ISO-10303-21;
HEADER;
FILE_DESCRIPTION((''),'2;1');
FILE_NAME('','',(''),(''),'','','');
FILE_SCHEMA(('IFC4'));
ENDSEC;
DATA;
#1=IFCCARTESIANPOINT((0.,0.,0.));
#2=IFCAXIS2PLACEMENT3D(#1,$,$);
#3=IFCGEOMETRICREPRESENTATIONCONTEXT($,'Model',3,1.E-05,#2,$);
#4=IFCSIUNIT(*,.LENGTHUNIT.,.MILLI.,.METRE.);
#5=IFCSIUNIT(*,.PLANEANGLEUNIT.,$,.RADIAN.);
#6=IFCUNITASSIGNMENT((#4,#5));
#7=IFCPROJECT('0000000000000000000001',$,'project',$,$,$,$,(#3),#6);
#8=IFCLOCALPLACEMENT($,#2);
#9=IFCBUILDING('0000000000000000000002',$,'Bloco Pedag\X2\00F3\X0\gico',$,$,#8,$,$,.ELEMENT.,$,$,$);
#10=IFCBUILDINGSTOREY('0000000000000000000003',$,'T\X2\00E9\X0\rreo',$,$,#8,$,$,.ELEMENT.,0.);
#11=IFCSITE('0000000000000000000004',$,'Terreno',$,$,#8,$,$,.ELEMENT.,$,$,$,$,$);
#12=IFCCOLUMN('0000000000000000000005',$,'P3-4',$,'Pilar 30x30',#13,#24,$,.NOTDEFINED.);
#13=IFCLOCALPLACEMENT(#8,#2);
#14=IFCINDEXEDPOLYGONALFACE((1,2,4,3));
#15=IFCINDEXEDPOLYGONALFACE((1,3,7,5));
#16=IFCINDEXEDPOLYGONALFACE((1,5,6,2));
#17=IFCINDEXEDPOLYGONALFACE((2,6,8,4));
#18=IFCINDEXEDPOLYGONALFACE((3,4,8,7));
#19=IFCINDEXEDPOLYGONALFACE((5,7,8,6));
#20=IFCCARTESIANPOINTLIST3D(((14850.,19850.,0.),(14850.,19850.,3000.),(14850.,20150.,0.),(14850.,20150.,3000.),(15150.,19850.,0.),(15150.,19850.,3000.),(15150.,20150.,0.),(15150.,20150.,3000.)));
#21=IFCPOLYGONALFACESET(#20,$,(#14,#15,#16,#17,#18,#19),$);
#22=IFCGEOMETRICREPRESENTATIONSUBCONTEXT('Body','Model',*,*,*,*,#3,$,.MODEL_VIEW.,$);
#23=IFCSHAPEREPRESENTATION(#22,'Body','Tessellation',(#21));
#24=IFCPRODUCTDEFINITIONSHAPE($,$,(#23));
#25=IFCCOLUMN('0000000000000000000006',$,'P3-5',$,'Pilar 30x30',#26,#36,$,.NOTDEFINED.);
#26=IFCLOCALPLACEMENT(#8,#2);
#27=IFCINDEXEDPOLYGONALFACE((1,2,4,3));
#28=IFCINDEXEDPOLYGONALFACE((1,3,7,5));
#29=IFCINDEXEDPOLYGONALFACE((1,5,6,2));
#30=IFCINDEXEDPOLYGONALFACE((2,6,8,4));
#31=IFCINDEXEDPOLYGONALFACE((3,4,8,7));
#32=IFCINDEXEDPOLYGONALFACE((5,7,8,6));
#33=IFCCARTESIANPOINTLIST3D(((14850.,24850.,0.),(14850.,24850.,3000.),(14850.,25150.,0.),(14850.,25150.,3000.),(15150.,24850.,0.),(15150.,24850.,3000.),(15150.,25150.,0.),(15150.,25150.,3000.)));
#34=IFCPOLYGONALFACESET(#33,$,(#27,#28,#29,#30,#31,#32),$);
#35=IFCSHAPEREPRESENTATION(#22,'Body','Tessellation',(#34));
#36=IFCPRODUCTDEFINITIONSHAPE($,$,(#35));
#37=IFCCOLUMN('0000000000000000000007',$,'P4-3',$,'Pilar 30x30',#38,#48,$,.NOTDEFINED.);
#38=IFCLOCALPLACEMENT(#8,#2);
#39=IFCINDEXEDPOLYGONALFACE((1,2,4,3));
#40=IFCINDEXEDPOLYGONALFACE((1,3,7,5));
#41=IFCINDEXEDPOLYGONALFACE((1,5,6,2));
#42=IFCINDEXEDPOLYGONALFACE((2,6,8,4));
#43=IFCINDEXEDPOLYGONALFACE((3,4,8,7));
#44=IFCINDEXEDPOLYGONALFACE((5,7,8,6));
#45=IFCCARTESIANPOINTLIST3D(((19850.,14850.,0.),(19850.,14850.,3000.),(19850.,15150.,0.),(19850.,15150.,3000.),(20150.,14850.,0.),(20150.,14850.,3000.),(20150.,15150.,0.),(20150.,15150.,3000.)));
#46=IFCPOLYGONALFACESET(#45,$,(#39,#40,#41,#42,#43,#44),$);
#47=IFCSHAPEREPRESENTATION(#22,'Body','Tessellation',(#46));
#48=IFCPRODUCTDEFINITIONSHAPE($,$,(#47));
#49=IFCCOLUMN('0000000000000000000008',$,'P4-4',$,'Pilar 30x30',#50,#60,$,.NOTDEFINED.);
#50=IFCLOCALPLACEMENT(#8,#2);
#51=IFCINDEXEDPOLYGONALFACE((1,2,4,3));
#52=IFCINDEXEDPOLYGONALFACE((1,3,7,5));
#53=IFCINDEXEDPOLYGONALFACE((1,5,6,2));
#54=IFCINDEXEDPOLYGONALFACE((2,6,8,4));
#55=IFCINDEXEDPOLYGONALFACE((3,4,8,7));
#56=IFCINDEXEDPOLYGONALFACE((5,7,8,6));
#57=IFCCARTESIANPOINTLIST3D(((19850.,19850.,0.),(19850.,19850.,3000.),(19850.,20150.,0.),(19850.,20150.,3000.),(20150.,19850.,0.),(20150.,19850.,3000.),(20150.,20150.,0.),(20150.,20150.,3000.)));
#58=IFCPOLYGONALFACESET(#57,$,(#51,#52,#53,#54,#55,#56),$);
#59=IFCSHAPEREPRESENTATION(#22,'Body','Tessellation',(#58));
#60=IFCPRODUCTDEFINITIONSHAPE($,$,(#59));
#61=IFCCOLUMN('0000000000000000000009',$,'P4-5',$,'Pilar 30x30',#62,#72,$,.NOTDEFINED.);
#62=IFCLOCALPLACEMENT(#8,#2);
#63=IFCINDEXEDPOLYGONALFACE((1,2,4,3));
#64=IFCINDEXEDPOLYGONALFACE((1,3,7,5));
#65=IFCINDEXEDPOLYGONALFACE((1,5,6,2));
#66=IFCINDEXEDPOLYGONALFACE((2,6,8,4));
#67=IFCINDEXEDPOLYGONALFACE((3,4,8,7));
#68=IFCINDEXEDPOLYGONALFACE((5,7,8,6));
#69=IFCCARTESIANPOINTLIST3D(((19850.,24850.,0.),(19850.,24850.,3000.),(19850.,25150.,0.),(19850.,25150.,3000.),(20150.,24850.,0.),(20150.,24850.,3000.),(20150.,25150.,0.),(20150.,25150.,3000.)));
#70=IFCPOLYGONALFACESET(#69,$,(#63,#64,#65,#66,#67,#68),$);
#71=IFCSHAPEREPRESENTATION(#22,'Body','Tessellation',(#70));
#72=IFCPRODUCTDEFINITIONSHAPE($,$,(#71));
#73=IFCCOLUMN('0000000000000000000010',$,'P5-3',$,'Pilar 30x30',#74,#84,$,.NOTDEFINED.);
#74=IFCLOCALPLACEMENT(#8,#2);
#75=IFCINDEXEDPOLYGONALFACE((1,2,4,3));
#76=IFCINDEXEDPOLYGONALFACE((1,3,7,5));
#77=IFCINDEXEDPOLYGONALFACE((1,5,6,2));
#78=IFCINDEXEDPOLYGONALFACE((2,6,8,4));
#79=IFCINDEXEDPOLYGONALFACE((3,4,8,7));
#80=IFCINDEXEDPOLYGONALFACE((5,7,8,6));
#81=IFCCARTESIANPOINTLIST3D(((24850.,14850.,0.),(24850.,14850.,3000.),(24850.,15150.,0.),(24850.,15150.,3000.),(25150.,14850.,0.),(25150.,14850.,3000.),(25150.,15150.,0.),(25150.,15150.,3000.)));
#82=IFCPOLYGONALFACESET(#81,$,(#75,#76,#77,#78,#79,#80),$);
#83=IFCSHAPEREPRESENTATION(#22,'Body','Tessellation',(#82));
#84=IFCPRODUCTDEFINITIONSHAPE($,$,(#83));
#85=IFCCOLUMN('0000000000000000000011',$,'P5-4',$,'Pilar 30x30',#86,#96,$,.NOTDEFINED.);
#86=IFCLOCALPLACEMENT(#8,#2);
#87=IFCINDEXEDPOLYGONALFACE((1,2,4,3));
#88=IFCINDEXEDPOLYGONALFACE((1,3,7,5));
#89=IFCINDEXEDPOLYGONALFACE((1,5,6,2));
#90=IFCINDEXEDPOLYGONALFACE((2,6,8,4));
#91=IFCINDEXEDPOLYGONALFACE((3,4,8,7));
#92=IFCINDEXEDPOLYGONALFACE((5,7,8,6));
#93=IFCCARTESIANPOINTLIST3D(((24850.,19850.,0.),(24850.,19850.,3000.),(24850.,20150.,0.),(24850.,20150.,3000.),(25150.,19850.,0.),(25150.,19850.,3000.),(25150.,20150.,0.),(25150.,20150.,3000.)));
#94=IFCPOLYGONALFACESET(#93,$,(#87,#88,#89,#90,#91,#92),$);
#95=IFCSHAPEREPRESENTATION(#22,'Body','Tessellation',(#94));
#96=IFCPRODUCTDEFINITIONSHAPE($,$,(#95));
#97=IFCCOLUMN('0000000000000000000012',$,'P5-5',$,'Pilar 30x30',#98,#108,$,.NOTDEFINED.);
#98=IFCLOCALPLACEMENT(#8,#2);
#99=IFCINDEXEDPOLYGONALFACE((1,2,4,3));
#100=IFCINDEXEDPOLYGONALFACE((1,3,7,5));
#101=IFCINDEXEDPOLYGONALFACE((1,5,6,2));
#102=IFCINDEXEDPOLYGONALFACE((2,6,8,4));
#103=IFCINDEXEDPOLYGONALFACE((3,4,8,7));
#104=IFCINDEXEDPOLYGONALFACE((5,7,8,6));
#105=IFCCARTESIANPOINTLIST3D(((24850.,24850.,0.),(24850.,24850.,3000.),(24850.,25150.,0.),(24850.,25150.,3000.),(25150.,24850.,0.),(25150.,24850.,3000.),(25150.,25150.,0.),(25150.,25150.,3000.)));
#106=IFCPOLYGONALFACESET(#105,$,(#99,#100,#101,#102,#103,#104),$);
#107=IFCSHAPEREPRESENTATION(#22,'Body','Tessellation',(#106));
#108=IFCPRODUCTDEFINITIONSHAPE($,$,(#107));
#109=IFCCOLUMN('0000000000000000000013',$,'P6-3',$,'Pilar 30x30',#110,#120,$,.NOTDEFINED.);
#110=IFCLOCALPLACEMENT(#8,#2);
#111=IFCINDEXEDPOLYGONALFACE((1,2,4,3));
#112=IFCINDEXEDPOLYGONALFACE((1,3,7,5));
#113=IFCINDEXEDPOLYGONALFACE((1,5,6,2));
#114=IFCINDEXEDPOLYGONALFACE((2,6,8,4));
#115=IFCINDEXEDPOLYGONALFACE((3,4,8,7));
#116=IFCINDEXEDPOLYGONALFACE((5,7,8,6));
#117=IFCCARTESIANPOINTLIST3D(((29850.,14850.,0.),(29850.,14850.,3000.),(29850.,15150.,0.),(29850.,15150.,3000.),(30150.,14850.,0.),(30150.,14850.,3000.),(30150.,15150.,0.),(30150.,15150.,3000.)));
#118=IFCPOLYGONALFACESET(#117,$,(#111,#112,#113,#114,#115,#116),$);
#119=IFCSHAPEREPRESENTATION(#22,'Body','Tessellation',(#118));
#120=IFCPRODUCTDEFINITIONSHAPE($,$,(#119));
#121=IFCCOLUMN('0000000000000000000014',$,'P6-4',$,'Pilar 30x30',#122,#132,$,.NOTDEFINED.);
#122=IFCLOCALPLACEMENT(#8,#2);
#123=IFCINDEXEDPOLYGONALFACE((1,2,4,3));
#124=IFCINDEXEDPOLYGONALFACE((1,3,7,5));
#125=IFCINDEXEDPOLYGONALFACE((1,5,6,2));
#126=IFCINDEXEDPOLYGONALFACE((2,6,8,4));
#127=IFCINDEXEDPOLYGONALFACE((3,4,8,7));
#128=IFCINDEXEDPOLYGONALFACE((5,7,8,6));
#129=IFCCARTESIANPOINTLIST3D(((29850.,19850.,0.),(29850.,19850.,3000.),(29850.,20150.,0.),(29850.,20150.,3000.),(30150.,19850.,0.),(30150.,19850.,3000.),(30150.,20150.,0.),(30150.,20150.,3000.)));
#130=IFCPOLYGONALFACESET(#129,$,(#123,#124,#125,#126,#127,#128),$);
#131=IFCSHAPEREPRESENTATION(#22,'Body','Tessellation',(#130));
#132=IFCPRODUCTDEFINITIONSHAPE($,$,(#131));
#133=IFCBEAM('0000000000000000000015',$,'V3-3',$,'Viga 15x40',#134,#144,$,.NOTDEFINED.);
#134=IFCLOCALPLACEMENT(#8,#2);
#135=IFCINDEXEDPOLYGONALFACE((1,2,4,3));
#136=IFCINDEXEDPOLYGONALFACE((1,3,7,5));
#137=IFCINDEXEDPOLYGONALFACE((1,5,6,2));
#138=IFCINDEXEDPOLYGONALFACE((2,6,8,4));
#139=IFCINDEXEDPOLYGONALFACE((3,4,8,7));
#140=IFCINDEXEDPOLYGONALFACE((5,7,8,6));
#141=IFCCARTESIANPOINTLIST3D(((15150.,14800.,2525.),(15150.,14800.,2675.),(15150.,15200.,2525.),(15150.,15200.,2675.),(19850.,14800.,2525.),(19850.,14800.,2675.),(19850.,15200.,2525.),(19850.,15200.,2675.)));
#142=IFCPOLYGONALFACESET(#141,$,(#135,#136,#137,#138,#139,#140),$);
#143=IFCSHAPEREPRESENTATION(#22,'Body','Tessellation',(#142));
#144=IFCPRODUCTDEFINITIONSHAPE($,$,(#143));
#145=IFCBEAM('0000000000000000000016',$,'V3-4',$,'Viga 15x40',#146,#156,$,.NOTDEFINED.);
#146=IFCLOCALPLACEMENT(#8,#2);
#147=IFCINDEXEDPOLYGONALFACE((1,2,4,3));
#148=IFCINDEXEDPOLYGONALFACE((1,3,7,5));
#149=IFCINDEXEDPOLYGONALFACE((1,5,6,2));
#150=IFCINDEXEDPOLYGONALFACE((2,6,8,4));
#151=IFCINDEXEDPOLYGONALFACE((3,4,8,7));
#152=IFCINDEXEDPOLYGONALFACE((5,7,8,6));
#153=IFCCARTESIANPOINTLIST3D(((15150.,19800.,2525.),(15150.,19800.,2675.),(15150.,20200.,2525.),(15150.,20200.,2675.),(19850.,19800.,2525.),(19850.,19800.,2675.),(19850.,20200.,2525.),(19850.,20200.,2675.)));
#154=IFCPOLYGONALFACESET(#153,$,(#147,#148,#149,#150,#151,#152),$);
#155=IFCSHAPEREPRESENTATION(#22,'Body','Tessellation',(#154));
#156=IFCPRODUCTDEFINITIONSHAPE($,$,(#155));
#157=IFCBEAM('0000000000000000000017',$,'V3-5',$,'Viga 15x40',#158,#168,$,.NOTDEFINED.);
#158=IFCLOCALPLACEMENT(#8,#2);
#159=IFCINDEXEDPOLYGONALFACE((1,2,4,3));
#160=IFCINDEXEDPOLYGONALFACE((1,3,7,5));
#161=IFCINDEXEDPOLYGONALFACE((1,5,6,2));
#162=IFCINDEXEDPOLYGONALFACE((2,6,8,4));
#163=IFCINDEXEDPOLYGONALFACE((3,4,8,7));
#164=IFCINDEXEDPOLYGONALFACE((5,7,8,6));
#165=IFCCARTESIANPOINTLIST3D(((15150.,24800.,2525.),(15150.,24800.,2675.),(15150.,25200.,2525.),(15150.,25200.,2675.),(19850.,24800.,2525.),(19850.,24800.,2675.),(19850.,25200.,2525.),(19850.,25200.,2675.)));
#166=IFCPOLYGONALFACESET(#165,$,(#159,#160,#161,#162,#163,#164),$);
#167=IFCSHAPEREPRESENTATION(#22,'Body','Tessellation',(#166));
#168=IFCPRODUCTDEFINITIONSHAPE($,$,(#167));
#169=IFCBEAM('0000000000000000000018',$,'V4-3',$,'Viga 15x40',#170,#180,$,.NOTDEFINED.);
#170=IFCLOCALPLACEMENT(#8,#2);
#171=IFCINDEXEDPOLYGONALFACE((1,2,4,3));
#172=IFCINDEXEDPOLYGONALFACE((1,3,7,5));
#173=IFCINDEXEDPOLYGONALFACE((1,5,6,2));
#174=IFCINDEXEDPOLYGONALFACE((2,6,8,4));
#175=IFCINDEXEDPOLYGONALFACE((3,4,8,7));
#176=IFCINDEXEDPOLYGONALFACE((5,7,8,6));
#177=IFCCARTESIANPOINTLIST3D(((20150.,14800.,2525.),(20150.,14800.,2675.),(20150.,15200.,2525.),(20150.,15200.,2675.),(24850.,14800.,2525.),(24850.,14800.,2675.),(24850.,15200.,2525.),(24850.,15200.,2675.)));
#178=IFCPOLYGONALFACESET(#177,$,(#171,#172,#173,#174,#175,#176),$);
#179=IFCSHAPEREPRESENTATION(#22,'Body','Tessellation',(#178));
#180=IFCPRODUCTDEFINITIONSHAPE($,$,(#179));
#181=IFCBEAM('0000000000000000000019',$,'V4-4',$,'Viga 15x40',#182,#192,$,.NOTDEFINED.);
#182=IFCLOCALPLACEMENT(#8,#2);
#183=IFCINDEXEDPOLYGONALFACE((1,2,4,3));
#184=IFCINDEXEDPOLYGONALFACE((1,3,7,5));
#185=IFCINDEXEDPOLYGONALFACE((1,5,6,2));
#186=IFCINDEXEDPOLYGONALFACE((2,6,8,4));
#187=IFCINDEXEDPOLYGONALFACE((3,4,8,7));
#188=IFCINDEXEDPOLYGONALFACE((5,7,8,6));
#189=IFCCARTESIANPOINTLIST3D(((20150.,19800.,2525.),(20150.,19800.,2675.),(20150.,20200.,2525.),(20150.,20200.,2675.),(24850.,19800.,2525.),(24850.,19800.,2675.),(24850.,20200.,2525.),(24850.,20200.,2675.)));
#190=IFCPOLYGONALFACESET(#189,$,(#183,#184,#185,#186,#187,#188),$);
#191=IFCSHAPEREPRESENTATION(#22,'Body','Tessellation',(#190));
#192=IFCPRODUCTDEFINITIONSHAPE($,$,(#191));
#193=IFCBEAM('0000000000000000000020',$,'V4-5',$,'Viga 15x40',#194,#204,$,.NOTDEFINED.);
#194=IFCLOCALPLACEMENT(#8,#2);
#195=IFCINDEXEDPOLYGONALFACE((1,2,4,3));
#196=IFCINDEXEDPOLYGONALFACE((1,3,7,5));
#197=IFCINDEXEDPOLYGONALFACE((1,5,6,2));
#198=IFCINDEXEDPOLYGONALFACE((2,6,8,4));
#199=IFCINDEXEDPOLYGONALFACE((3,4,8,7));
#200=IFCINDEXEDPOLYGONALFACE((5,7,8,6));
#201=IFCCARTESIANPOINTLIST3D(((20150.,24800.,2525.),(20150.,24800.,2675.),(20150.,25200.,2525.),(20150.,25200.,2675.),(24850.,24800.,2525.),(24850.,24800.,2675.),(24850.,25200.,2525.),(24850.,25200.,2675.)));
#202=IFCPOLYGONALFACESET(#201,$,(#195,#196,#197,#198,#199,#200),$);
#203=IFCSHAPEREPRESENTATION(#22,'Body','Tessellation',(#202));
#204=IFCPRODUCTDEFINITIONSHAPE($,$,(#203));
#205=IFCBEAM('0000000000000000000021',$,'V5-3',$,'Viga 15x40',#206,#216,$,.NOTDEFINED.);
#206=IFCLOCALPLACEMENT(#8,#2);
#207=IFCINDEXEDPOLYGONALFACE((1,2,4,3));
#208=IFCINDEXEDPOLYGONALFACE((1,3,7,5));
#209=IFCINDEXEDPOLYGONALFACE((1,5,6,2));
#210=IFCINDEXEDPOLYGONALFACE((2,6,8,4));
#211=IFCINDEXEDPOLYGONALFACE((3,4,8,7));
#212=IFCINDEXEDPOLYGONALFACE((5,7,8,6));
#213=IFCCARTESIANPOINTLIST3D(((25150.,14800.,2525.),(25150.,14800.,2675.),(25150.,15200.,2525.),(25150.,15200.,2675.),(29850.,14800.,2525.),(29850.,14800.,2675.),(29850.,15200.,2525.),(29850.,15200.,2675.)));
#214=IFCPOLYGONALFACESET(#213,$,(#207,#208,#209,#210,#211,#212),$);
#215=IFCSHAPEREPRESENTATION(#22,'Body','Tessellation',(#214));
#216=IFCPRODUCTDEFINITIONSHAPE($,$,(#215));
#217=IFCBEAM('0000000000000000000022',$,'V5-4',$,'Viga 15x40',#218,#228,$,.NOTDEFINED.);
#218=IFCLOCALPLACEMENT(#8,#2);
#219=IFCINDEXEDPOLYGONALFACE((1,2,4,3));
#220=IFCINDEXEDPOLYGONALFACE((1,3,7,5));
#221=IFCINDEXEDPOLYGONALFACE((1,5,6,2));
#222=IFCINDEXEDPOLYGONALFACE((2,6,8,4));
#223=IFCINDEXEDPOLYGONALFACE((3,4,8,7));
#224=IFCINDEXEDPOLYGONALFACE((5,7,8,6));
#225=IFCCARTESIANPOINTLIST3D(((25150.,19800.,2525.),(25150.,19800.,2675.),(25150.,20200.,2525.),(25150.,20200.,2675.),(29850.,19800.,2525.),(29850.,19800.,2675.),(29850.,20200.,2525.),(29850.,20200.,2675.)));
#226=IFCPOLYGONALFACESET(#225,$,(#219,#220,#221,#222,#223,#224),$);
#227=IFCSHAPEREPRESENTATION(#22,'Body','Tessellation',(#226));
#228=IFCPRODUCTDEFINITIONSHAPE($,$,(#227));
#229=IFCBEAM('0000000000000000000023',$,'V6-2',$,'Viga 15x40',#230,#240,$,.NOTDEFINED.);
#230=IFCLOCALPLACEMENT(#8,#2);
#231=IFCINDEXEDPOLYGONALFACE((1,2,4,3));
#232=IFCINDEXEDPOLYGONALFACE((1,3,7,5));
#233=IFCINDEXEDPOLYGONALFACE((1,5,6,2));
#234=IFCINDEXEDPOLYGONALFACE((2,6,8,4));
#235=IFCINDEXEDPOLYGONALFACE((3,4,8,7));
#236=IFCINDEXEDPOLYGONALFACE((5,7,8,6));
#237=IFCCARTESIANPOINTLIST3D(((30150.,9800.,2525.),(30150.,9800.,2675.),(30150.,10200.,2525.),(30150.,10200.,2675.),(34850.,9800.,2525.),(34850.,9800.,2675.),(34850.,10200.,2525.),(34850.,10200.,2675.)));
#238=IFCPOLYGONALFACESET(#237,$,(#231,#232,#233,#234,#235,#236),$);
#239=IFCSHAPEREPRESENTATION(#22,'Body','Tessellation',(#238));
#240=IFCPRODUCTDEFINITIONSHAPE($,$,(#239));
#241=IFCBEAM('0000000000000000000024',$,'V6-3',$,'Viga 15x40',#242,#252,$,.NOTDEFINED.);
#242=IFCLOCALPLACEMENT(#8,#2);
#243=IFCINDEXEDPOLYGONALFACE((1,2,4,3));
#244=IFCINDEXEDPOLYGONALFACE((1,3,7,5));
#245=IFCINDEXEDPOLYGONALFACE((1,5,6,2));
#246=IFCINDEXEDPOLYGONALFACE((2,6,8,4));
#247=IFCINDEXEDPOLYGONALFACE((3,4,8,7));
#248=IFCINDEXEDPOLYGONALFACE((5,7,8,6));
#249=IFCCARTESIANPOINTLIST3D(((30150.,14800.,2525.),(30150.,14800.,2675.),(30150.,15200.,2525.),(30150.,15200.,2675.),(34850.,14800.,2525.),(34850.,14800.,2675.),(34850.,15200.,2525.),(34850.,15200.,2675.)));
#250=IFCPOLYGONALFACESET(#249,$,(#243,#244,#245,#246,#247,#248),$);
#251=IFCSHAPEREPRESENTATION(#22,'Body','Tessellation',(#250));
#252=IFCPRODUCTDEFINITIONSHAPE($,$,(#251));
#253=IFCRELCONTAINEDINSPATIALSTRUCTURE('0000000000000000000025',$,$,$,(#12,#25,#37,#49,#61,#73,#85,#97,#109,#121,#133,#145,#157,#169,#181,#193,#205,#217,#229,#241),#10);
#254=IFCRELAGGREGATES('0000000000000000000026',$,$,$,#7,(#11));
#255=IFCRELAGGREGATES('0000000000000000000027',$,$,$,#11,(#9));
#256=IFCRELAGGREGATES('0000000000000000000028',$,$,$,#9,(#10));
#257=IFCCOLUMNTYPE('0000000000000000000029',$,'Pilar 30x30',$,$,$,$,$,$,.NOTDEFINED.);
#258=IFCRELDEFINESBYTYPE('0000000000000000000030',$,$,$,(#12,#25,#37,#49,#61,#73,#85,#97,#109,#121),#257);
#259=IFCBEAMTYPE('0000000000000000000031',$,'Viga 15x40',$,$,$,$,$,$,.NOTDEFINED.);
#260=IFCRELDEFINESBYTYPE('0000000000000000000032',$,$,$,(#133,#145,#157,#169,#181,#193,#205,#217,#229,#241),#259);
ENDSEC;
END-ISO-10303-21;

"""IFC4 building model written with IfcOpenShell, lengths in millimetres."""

from ifc_helpers import new_model, si_unit, frame, origin, origin_2d, place, context, subcontext, project, spatial, rectangle, extrude, type_object, element, save


model = new_model("IFC4")

# Units and contexts
model_context = context("Model", 3, precision=1e-05, world=origin())
body_context = subcontext(model_context, "Body", "Model", "MODEL_VIEW")
ifc_project = project(units=[si_unit("LENGTHUNIT", "METRE", prefix="MILLI"), si_unit("PLANEANGLEUNIT", "RADIAN")], contexts=[model_context])

# Site, building, storey
placement = place(None, origin())
site = spatial("IfcSite", under=ifc_project, at=placement, Name="Terreno", CompositionType="ELEMENT")
building = spatial("IfcBuilding", under=site, at=placement, Name="Bloco Pedagógico", CompositionType="ELEMENT")
storey = spatial("IfcBuildingStorey", under=building, at=placement, Name="Térreo", CompositionType="ELEMENT", Elevation=0.0)

# Columns
column_type = type_object("IfcColumnType", Name="Pilar 30x30", PredefinedType="NOTDEFINED")
for number, where, z_axis, x_axis, name in (
    (1, (15000.0, 20000.0, 0.0), (0.0, 0.0, 1.0), (1.0, 0.0, 0.0), "P3-4"),
    (2, (15000.0, 25000.0, 0.0), (0.0, 0.0, 1.0), (1.0, 0.0, 0.0), "P3-5"),
    (3, (20000.0, 15000.0, 0.0), (0.0, 0.0, 1.0), (1.0, 0.0, 0.0), "P4-3"),
    (4, (20000.0, 20000.0, 0.0), (0.0, 0.0, 1.0), (1.0, 0.0, 0.0), "P4-4"),
    (5, (20000.0, 25000.0, 0.0), (0.0, 0.0, 1.0), (1.0, 0.0, 0.0), "P4-5"),
    (6, (25000.0, 15000.0, 0.0), (0.0, 0.0, 1.0), (1.0, 0.0, 0.0), "P5-3"),
    (7, (25000.0, 20000.0, 0.0), (0.0, 0.0, 1.0), (1.0, 0.0, 0.0), "P5-4"),
    (8, (25000.0, 25000.0, 0.0), (0.0, 0.0, 1.0), (1.0, 0.0, 0.0), "P5-5"),
    (9, (30000.0, 15000.0, 0.0), (0.0, 0.0, 1.0), (1.0, 0.0, 0.0), "P6-3"),
    (10, (30000.0, 20000.0, 0.0), (0.0, 0.0, 1.0), (1.0, 0.0, 0.0), "P6-4"),
):
    element("IfcColumn", number, at=place(None, frame(where, z_axis=z_axis, x_axis=x_axis)), inside=storey, type_object=column_type, Name=name, ObjectType="Pilar 30x30", PredefinedType="NOTDEFINED", context=body_context, shape_type="SweptSolid", body=[
        extrude(rectangle(XDim=300.0, YDim=300.0, at=origin_2d()), None, (0.0, 0.0, 1.0), 3000.0),
    ])

# Beams
beam_type = type_object("IfcBeamType", Name="Viga 15x40", PredefinedType="NOTDEFINED")
for number, where, z_axis, x_axis, name in (
    (11, (15150.0, 15000.0, 2600.0), (1.0, 0.0, 0.0), (0.0, 1.0, 0.0), "V3-3"),
    (12, (15150.0, 20000.0, 2600.0), (1.0, 0.0, 0.0), (0.0, 1.0, 0.0), "V3-4"),
    (13, (15150.0, 25000.0, 2600.0), (1.0, 0.0, 0.0), (0.0, 1.0, 0.0), "V3-5"),
    (14, (20150.0, 15000.0, 2600.0), (1.0, 0.0, 0.0), (0.0, 1.0, 0.0), "V4-3"),
    (15, (20150.0, 20000.0, 2600.0), (1.0, 0.0, 0.0), (0.0, 1.0, 0.0), "V4-4"),
    (16, (20150.0, 25000.0, 2600.0), (1.0, 0.0, 0.0), (0.0, 1.0, 0.0), "V4-5"),
    (17, (25150.0, 15000.0, 2600.0), (1.0, 0.0, 0.0), (0.0, 1.0, 0.0), "V5-3"),
    (18, (25150.0, 20000.0, 2600.0), (1.0, 0.0, 0.0), (0.0, 1.0, 0.0), "V5-4"),
    (19, (30150.0, 10000.0, 2600.0), (1.0, 0.0, 0.0), (0.0, 1.0, 0.0), "V6-2"),
    (20, (30150.0, 15000.0, 2600.0), (1.0, 0.0, 0.0), (0.0, 1.0, 0.0), "V6-3"),
):
    element("IfcBeam", number, at=place(None, frame(where, z_axis=z_axis, x_axis=x_axis)), inside=storey, type_object=beam_type, Name=name, ObjectType="Viga 15x40", PredefinedType="NOTDEFINED", context=body_context, shape_type="SweptSolid", body=[
        extrude(rectangle(XDim=400.0, YDim=150.0, at=origin_2d()), None, (0.0, 0.0, 1.0), 4700.0),
    ])

save(model, "model.ifc")
